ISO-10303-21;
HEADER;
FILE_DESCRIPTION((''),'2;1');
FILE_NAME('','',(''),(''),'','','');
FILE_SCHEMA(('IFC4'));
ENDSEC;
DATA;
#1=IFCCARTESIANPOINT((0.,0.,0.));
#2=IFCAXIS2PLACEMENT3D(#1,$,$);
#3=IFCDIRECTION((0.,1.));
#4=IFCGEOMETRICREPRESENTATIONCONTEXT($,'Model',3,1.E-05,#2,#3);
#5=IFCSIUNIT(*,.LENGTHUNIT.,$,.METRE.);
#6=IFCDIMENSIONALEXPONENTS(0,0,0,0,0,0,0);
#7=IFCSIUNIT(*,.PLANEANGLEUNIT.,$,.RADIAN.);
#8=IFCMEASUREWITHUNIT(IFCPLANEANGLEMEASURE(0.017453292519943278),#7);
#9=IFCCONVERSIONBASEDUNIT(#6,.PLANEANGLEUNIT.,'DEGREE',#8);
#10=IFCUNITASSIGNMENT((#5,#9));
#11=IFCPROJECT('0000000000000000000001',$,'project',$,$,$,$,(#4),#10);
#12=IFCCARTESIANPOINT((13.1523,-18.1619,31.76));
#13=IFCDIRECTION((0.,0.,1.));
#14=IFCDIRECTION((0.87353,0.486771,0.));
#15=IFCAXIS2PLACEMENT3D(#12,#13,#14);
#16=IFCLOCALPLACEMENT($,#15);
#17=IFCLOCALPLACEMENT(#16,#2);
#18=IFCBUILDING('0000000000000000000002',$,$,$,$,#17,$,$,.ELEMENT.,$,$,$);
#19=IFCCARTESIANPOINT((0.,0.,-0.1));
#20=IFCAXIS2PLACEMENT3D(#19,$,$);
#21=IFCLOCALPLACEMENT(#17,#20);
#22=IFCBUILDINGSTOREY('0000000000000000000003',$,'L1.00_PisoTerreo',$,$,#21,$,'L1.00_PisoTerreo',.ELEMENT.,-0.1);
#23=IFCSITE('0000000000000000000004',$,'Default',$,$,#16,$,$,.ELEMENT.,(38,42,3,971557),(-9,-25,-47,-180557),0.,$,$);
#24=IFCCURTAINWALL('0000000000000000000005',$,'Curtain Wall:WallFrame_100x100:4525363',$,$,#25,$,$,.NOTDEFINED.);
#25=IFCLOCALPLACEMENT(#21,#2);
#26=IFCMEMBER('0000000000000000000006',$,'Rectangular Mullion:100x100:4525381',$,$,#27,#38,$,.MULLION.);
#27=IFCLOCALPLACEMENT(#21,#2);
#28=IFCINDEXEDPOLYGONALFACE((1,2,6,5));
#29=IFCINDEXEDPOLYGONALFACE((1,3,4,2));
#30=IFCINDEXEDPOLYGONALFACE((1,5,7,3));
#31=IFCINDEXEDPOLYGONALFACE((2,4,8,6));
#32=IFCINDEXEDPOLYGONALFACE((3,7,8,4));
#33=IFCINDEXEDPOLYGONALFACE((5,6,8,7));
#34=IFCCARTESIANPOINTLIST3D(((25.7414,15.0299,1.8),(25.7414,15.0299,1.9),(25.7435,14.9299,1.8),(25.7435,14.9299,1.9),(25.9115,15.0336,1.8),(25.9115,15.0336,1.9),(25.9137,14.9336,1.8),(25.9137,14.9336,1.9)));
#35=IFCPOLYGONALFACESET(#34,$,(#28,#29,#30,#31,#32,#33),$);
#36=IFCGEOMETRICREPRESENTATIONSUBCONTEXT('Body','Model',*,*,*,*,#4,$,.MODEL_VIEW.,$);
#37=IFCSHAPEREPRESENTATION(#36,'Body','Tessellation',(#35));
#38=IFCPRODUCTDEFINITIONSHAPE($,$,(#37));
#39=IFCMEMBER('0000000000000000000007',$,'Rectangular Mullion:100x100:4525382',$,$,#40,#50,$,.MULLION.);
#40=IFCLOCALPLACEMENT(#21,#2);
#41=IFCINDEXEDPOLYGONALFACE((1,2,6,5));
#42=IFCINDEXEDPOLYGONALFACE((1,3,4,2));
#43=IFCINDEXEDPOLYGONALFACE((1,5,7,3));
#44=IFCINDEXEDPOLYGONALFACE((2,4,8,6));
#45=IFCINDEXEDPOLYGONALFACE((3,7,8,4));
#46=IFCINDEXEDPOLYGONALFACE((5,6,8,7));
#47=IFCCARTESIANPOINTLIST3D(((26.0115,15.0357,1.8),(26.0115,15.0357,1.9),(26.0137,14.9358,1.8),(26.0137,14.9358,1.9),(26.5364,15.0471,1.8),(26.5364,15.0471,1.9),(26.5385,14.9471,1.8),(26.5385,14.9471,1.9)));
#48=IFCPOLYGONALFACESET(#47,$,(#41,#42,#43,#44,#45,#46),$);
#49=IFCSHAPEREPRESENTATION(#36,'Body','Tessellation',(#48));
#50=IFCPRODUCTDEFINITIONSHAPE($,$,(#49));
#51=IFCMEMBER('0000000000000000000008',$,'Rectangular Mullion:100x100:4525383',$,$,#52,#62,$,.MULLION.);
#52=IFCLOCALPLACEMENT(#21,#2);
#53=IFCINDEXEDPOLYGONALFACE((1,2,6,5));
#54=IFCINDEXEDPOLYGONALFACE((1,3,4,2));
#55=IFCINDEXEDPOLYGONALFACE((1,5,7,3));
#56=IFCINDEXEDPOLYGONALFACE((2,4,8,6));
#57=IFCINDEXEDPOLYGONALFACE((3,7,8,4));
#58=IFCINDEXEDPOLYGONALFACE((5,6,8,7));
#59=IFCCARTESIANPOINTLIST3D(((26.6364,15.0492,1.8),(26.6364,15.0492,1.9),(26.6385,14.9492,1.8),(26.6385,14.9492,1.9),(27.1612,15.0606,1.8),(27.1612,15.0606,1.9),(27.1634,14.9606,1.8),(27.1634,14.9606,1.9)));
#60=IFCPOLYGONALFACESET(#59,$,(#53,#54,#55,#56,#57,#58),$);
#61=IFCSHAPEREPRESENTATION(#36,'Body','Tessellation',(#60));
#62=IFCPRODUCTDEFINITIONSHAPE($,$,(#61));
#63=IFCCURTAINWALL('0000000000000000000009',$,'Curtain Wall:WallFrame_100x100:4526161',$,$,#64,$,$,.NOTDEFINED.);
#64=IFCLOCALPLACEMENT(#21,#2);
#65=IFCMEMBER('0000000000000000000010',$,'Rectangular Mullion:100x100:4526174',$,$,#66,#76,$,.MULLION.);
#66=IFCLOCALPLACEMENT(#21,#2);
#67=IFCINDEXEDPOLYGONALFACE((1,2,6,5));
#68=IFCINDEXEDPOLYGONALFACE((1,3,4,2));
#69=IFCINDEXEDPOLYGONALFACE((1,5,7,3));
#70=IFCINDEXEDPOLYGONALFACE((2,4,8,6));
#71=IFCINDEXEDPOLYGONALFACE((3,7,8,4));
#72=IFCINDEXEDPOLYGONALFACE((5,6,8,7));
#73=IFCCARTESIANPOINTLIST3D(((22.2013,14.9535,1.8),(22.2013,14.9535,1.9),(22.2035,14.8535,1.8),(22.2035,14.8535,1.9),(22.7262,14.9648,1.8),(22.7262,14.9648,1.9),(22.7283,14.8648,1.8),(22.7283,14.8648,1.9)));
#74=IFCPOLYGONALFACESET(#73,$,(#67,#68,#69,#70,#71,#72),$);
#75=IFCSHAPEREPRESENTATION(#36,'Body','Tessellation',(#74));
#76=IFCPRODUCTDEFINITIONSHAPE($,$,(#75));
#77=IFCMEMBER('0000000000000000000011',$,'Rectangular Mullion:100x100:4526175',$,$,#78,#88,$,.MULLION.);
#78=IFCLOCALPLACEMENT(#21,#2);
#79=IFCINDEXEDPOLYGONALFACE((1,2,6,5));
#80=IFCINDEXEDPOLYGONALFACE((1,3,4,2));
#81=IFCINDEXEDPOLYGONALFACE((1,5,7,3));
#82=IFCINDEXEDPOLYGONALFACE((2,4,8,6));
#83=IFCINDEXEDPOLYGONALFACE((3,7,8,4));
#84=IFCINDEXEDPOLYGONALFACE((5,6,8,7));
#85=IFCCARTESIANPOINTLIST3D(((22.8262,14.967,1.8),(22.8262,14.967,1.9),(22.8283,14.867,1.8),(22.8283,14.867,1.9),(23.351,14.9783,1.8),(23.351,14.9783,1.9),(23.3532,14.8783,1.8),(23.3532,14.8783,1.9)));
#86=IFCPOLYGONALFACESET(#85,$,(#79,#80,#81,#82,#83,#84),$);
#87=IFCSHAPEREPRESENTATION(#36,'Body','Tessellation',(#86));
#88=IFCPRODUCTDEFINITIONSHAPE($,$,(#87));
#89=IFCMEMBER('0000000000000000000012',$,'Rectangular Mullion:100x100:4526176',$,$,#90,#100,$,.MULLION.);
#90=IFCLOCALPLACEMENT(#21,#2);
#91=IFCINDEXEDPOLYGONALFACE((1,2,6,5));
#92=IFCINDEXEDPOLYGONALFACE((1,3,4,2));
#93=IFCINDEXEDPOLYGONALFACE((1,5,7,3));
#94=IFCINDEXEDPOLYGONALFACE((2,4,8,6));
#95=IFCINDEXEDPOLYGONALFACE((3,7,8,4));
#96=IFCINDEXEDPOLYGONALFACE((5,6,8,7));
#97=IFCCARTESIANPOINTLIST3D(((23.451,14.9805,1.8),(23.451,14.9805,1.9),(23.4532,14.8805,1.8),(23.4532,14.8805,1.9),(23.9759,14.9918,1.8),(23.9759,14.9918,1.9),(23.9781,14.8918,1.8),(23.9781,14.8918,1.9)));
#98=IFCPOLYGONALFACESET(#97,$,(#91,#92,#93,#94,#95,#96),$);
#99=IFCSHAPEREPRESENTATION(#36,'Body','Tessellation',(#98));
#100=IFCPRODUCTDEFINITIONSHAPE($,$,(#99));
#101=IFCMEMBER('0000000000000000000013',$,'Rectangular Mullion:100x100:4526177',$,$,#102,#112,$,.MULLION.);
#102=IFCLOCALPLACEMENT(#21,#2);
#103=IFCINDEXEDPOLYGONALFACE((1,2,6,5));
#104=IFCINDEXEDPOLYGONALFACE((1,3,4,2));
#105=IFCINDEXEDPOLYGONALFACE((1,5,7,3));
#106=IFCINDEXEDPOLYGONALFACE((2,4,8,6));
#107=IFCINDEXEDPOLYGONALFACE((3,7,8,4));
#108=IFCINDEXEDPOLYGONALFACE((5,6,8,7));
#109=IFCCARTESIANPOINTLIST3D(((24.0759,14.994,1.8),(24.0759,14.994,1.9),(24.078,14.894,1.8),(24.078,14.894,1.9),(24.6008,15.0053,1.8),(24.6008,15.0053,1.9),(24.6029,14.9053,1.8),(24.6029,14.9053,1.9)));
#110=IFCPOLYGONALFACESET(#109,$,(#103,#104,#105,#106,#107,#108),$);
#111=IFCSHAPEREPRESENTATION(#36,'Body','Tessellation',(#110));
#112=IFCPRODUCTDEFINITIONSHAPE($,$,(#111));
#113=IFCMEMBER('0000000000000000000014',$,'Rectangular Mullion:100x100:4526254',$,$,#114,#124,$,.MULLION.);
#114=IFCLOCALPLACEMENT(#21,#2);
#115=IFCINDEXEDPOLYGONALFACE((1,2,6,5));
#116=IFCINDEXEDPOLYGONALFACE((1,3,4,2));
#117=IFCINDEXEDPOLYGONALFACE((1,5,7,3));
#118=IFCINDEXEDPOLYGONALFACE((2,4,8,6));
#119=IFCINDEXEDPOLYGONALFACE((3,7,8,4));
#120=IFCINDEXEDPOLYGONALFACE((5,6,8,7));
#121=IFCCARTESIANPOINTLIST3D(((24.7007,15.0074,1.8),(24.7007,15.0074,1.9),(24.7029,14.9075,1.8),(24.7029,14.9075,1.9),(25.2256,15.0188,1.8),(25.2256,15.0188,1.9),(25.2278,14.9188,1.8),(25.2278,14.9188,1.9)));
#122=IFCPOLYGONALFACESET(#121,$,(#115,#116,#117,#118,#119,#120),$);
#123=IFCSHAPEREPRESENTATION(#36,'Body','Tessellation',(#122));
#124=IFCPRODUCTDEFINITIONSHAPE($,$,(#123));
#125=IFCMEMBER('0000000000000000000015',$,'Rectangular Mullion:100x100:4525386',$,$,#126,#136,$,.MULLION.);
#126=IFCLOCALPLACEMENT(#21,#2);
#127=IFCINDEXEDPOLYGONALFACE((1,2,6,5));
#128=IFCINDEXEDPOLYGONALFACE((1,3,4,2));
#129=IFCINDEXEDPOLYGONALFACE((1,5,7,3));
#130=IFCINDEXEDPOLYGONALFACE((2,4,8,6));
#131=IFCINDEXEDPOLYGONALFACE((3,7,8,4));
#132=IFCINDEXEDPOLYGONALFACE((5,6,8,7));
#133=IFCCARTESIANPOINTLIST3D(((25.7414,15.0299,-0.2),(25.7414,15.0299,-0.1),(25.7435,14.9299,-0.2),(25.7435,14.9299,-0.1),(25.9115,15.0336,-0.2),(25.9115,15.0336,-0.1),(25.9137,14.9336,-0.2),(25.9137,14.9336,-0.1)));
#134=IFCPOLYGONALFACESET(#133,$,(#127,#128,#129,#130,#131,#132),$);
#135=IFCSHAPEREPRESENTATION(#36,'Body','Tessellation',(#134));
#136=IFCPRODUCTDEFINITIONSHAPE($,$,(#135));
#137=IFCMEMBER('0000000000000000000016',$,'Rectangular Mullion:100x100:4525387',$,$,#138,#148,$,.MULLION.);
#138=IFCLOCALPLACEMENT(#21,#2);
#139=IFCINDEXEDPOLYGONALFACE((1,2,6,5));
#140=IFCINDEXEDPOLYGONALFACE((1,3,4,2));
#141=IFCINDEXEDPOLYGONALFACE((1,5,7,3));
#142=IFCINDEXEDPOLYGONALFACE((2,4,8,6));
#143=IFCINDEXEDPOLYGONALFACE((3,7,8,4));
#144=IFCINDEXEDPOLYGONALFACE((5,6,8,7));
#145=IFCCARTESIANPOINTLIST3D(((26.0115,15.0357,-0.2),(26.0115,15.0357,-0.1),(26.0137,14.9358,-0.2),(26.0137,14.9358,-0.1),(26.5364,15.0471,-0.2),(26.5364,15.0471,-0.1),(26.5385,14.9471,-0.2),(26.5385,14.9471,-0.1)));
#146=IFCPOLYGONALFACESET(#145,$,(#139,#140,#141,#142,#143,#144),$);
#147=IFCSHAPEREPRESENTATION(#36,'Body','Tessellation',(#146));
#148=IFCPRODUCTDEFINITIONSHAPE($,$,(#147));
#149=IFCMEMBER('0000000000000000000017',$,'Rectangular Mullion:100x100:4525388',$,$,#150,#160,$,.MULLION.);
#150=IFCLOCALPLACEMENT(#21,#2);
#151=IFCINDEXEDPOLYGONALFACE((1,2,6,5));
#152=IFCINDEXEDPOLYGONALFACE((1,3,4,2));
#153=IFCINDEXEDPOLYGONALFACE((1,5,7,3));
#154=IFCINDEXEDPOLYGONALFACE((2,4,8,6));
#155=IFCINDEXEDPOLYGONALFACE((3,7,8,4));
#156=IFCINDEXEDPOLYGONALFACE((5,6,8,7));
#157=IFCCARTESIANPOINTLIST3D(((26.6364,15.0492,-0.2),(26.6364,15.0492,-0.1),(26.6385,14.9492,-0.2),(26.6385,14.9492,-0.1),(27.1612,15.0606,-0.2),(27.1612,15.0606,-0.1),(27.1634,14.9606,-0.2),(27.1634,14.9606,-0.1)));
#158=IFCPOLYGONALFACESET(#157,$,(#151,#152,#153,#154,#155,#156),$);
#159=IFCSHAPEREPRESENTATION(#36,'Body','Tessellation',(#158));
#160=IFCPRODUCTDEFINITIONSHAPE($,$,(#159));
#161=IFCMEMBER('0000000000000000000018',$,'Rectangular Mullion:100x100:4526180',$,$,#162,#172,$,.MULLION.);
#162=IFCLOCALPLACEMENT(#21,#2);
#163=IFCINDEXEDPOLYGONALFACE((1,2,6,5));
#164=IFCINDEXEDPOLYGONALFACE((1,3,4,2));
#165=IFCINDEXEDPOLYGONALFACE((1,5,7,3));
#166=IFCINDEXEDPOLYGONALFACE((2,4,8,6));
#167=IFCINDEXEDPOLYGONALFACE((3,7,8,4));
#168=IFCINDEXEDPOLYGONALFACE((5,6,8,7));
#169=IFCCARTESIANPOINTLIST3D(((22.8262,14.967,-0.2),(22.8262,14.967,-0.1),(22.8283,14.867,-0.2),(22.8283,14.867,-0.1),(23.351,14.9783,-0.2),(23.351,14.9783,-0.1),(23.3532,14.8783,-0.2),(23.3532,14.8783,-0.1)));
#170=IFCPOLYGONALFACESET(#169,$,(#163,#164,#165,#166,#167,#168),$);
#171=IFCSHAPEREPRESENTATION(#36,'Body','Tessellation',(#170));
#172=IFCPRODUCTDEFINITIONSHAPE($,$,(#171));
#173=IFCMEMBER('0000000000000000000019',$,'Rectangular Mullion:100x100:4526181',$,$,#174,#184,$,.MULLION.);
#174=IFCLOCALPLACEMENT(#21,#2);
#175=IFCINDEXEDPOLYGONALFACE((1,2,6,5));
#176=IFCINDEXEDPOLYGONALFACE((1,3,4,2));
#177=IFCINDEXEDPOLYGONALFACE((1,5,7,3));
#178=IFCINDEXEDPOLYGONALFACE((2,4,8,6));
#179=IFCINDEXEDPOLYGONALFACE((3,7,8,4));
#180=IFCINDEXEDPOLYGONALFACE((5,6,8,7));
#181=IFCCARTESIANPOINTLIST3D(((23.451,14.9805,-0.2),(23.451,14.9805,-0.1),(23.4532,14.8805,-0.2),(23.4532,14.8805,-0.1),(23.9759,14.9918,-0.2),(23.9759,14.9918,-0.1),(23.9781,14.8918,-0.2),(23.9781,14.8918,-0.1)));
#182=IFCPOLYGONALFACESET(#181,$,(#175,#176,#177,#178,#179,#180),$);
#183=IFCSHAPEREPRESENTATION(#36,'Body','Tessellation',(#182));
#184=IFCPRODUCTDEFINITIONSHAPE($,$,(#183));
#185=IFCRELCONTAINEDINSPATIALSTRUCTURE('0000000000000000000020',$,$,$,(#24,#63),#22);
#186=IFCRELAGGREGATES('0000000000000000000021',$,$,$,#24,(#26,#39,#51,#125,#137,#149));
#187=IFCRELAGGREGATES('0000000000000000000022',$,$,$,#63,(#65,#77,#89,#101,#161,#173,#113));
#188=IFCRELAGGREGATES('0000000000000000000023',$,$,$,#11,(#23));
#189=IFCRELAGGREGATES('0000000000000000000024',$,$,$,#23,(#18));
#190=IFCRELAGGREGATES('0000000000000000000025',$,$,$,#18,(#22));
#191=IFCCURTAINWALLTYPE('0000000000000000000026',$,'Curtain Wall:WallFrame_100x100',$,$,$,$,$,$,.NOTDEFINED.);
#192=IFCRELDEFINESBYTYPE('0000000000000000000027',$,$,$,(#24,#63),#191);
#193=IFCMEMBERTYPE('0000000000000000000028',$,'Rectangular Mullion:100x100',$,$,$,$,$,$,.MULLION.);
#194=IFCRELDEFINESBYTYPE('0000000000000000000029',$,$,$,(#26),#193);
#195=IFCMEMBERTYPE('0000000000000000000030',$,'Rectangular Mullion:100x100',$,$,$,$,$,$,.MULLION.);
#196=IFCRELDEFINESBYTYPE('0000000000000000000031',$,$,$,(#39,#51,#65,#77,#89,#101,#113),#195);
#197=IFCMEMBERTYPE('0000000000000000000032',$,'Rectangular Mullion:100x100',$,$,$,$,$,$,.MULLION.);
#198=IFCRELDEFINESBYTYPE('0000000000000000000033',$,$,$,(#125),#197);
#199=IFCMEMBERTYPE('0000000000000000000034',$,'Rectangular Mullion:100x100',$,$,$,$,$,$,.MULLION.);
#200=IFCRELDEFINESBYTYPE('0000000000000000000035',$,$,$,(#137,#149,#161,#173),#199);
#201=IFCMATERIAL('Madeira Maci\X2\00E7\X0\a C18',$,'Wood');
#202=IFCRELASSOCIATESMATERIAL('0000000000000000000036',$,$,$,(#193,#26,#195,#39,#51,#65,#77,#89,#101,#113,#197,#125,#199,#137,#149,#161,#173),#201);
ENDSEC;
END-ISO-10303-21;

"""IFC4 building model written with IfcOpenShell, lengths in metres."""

from ifc_helpers import new_model, entity, si_unit, converted_unit, direction, frame, origin, place, context, subcontext, project, spatial, indexed_curve, outline, extrude, source, transform, mapped, material, type_object, type_shapes, element, aggregate, save


model = new_model("IFC4")

# Units and contexts
model_context = context("Model", 3, precision=1e-05, world=origin(), true_north=direction((0.0, 1.0)))
body_context = subcontext(model_context, "Body", "Model", "MODEL_VIEW")
ifc_project = project(units=[si_unit("LENGTHUNIT", "METRE"), converted_unit("PLANEANGLEUNIT", "DEGREE", entity("IfcPlaneAngleMeasure", 0.017453292519943278), si_unit("PLANEANGLEUNIT", "RADIAN"), dimensions=[0, 0, 0, 0, 0, 0, 0])], contexts=[model_context])

# Site, building, storey
site_placement = place(None, frame((13.1523, -18.1619, 31.76), z_axis=(0.0, 0.0, 1.0), x_axis=(0.87353, 0.486771, 0.0)))
site = spatial("IfcSite", under=ifc_project, at=site_placement, Name="Default", CompositionType="ELEMENT", RefLatitude=(38, 42, 3, 971557), RefLongitude=(-9, -25, -47, -180557), RefElevation=0.0)
building_placement = place(site_placement, origin())
building = spatial("IfcBuilding", under=site, at=building_placement, CompositionType="ELEMENT")
storey_placement = place(building_placement, frame((0.0, 0.0, -0.1)))
storey = spatial("IfcBuildingStorey", under=building, at=storey_placement, Name="L1.00_PisoTerreo", LongName="L1.00_PisoTerreo", CompositionType="ELEMENT", Elevation=-0.1)

# Curtain walls, members
curtain_wall_type = type_object("IfcCurtainWallType", Name="Curtain Wall:WallFrame_100x100", PredefinedType="NOTDEFINED")
curtain_wall_1_placement = place(storey_placement, frame((0.0, 0.0, 0.1)))
curtain_wall_1 = element("IfcCurtainWall", 1, at=curtain_wall_1_placement, inside=storey, type_object=curtain_wall_type, Name="Curtain Wall:WallFrame_100x100:4525363", PredefinedType="NOTDEFINED")
ifc_material_1 = material(Name="Madeira Maciça C18", Category="Wood")
member_type_1 = type_object("IfcMemberType", Name="Rectangular Mullion:100x100", PredefinedType="MULLION", material=ifc_material_1)
shared_shape_1 = source(origin(), body_context, "Body", "SweptSolid", [
    extrude(outline(indexed_curve([(-0.05, -0.05), (0.05, -0.05), (0.05, 0.05), (-0.05, 0.05), (-0.05, -0.05)], self_intersect=False)), frame((-0.05, 0.0, -0.1702), z_axis=(0.0, 0.0, 1.0), x_axis=(-1.0, 0.0, 0.0)), (0.0, 0.0, 1.0), 0.1702),
])
type_shapes(member_type_1, [shared_shape_1])
member_1_placement = place(curtain_wall_1_placement, frame((25.9126, 14.9836, 1.8), z_axis=(0.999767, 0.021581, 0.0), x_axis=(0.0, 0.0, 1.0)))
member_1 = element("IfcMember", 2, at=member_1_placement, type_object=member_type_1, material=ifc_material_1, Name="Rectangular Mullion:100x100:4525381", PredefinedType="MULLION", context=body_context, shape_type="MappedRepresentation", body=[
    mapped(shared_shape_1, transform((0.0, 0.0, 0.0), scale=1.0)),
])
member_type_2 = type_object("IfcMemberType", Name="Rectangular Mullion:100x100", PredefinedType="MULLION", material=ifc_material_1)
shared_shape_2 = source(origin(), body_context, "Body", "SweptSolid", [
    extrude(outline(indexed_curve([(-0.05, -0.05), (0.05, -0.05), (0.05, 0.05), (-0.05, 0.05), (-0.05, -0.05)], self_intersect=False)), frame((-0.05, 0.0, -0.525), z_axis=(0.0, 0.0, 1.0), x_axis=(-1.0, 0.0, 0.0)), (0.0, 0.0, 1.0), 0.525),
])
type_shapes(member_type_2, [shared_shape_2])
member_2_placement = place(curtain_wall_1_placement, frame((26.5375, 14.9971, 1.8), z_axis=(0.999767, 0.021581, 0.0), x_axis=(0.0, 0.0, 1.0)))
member_2 = element("IfcMember", 3, at=member_2_placement, type_object=member_type_2, material=ifc_material_1, Name="Rectangular Mullion:100x100:4525382", PredefinedType="MULLION", context=body_context, shape_type="MappedRepresentation", body=[
    mapped(shared_shape_2, transform((0.0, 0.0, 0.0), scale=1.0)),
])
member_3_placement = place(curtain_wall_1_placement, frame((27.1623, 15.0106, 1.8), z_axis=(0.999767, 0.021581, 0.0), x_axis=(0.0, 0.0, 1.0)))
member_3 = element("IfcMember", 4, at=member_3_placement, type_object=member_type_2, material=ifc_material_1, Name="Rectangular Mullion:100x100:4525383", PredefinedType="MULLION", context=body_context, shape_type="MappedRepresentation", body=[
    mapped(shared_shape_2, transform((0.0, 0.0, 0.0), scale=1.0)),
])
curtain_wall_2_placement = place(storey_placement, frame((0.0, 0.0, 0.1)))
curtain_wall_2 = element("IfcCurtainWall", 5, at=curtain_wall_2_placement, inside=storey, type_object=curtain_wall_type, Name="Curtain Wall:WallFrame_100x100:4526161", PredefinedType="NOTDEFINED")
member_4_placement = place(curtain_wall_2_placement, frame((22.7273, 14.9148, 1.8), z_axis=(0.999767, 0.021581, 0.0), x_axis=(0.0, 0.0, 1.0)))
member_4 = element("IfcMember", 6, at=member_4_placement, type_object=member_type_2, material=ifc_material_1, Name="Rectangular Mullion:100x100:4526174", PredefinedType="MULLION", context=body_context, shape_type="MappedRepresentation", body=[
    mapped(shared_shape_2, transform((0.0, 0.0, 0.0), scale=1.0)),
])
member_5_placement = place(curtain_wall_2_placement, frame((23.3521, 14.9283, 1.8), z_axis=(0.999767, 0.021581, 0.0), x_axis=(0.0, 0.0, 1.0)))
member_5 = element("IfcMember", 7, at=member_5_placement, type_object=member_type_2, material=ifc_material_1, Name="Rectangular Mullion:100x100:4526175", PredefinedType="MULLION", context=body_context, shape_type="MappedRepresentation", body=[
    mapped(shared_shape_2, transform((0.0, 0.0, 0.0), scale=1.0)),
])
member_6_placement = place(curtain_wall_2_placement, frame((23.977, 14.9418, 1.8), z_axis=(0.999767, 0.021581, 0.0), x_axis=(0.0, 0.0, 1.0)))
member_6 = element("IfcMember", 8, at=member_6_placement, type_object=member_type_2, material=ifc_material_1, Name="Rectangular Mullion:100x100:4526176", PredefinedType="MULLION", context=body_context, shape_type="MappedRepresentation", body=[
    mapped(shared_shape_2, transform((0.0, 0.0, 0.0), scale=1.0)),
])
member_7_placement = place(curtain_wall_2_placement, frame((24.6018, 14.9553, 1.8), z_axis=(0.999767, 0.021581, 0.0), x_axis=(0.0, 0.0, 1.0)))
member_7 = element("IfcMember", 9, at=member_7_placement, type_object=member_type_2, material=ifc_material_1, Name="Rectangular Mullion:100x100:4526177", PredefinedType="MULLION", context=body_context, shape_type="MappedRepresentation", body=[
    mapped(shared_shape_2, transform((0.0, 0.0, 0.0), scale=1.0)),
])
member_8_placement = place(curtain_wall_2_placement, frame((25.2267, 14.9688, 1.8), z_axis=(0.999767, 0.021581, 0.0), x_axis=(0.0, 0.0, 1.0)))
member_8 = element("IfcMember", 10, at=member_8_placement, type_object=member_type_2, material=ifc_material_1, Name="Rectangular Mullion:100x100:4526254", PredefinedType="MULLION", context=body_context, shape_type="MappedRepresentation", body=[
    mapped(shared_shape_2, transform((0.0, 0.0, 0.0), scale=1.0)),
])

# Members
member_type_3 = type_object("IfcMemberType", Name="Rectangular Mullion:100x100", PredefinedType="MULLION", material=ifc_material_1)
shared_shape_3 = source(origin(), body_context, "Body", "SweptSolid", [
    extrude(outline(indexed_curve([(-0.05, -0.05), (0.05, -0.05), (0.05, 0.05), (-0.05, 0.05), (-0.05, -0.05)], self_intersect=False)), frame((-0.05, 0.0, -0.1702), z_axis=(0.0, 0.0, 1.0), x_axis=(0.0, -1.0, 0.0)), (0.0, 0.0, 1.0), 0.1702),
])
type_shapes(member_type_3, [shared_shape_3])
member_9_placement = place(curtain_wall_1_placement, frame((25.7425, 14.9799, -0.3), z_axis=(-0.999767, -0.021581, 0.0), x_axis=(0.0, 0.0, -1.0)))
member_9 = element("IfcMember", 11, at=member_9_placement, type_object=member_type_3, material=ifc_material_1, Name="Rectangular Mullion:100x100:4525386", PredefinedType="MULLION", context=body_context, shape_type="MappedRepresentation", body=[
    mapped(shared_shape_3, transform((0.0, 0.0, 0.0), scale=1.0)),
])
member_type_4 = type_object("IfcMemberType", Name="Rectangular Mullion:100x100", PredefinedType="MULLION", material=ifc_material_1)
shared_shape_4 = source(origin(), body_context, "Body", "SweptSolid", [
    extrude(outline(indexed_curve([(-0.05, -0.05), (0.05, -0.05), (0.05, 0.05), (-0.05, 0.05), (-0.05, -0.05)], self_intersect=False)), frame((-0.05, 0.0, -0.525), z_axis=(0.0, 0.0, 1.0), x_axis=(0.0, -1.0, 0.0)), (0.0, 0.0, 1.0), 0.525),
])
type_shapes(member_type_4, [shared_shape_4])
member_10_placement = place(curtain_wall_1_placement, frame((26.0126, 14.9857, -0.3), z_axis=(-0.999767, -0.021581, 0.0), x_axis=(0.0, 0.0, -1.0)))
member_10 = element("IfcMember", 12, at=member_10_placement, type_object=member_type_4, material=ifc_material_1, Name="Rectangular Mullion:100x100:4525387", PredefinedType="MULLION", context=body_context, shape_type="MappedRepresentation", body=[
    mapped(shared_shape_4, transform((0.0, 0.0, 0.0), scale=1.0)),
])
member_11_placement = place(curtain_wall_1_placement, frame((26.6374, 14.9992, -0.3), z_axis=(-0.999767, -0.021581, 0.0), x_axis=(0.0, 0.0, -1.0)))
member_11 = element("IfcMember", 13, at=member_11_placement, type_object=member_type_4, material=ifc_material_1, Name="Rectangular Mullion:100x100:4525388", PredefinedType="MULLION", context=body_context, shape_type="MappedRepresentation", body=[
    mapped(shared_shape_4, transform((0.0, 0.0, 0.0), scale=1.0)),
])
member_12_placement = place(curtain_wall_2_placement, frame((22.8272, 14.917, -0.3), z_axis=(-0.999767, -0.021581, 0.0), x_axis=(0.0, 0.0, -1.0)))
member_12 = element("IfcMember", 14, at=member_12_placement, type_object=member_type_4, material=ifc_material_1, Name="Rectangular Mullion:100x100:4526180", PredefinedType="MULLION", context=body_context, shape_type="MappedRepresentation", body=[
    mapped(shared_shape_4, transform((0.0, 0.0, 0.0), scale=1.0)),
])
member_13_placement = place(curtain_wall_2_placement, frame((23.4521, 14.9305, -0.3), z_axis=(-0.999767, -0.021581, 0.0), x_axis=(0.0, 0.0, -1.0)))
member_13 = element("IfcMember", 15, at=member_13_placement, type_object=member_type_4, material=ifc_material_1, Name="Rectangular Mullion:100x100:4526181", PredefinedType="MULLION", context=body_context, shape_type="MappedRepresentation", body=[
    mapped(shared_shape_4, transform((0.0, 0.0, 0.0), scale=1.0)),
])
aggregate(curtain_wall_1, [member_1, member_2, member_3, member_9, member_10, member_11])
aggregate(curtain_wall_2, [member_4, member_5, member_6, member_7, member_12, member_13, member_8])

save(model, "model.ifc")
